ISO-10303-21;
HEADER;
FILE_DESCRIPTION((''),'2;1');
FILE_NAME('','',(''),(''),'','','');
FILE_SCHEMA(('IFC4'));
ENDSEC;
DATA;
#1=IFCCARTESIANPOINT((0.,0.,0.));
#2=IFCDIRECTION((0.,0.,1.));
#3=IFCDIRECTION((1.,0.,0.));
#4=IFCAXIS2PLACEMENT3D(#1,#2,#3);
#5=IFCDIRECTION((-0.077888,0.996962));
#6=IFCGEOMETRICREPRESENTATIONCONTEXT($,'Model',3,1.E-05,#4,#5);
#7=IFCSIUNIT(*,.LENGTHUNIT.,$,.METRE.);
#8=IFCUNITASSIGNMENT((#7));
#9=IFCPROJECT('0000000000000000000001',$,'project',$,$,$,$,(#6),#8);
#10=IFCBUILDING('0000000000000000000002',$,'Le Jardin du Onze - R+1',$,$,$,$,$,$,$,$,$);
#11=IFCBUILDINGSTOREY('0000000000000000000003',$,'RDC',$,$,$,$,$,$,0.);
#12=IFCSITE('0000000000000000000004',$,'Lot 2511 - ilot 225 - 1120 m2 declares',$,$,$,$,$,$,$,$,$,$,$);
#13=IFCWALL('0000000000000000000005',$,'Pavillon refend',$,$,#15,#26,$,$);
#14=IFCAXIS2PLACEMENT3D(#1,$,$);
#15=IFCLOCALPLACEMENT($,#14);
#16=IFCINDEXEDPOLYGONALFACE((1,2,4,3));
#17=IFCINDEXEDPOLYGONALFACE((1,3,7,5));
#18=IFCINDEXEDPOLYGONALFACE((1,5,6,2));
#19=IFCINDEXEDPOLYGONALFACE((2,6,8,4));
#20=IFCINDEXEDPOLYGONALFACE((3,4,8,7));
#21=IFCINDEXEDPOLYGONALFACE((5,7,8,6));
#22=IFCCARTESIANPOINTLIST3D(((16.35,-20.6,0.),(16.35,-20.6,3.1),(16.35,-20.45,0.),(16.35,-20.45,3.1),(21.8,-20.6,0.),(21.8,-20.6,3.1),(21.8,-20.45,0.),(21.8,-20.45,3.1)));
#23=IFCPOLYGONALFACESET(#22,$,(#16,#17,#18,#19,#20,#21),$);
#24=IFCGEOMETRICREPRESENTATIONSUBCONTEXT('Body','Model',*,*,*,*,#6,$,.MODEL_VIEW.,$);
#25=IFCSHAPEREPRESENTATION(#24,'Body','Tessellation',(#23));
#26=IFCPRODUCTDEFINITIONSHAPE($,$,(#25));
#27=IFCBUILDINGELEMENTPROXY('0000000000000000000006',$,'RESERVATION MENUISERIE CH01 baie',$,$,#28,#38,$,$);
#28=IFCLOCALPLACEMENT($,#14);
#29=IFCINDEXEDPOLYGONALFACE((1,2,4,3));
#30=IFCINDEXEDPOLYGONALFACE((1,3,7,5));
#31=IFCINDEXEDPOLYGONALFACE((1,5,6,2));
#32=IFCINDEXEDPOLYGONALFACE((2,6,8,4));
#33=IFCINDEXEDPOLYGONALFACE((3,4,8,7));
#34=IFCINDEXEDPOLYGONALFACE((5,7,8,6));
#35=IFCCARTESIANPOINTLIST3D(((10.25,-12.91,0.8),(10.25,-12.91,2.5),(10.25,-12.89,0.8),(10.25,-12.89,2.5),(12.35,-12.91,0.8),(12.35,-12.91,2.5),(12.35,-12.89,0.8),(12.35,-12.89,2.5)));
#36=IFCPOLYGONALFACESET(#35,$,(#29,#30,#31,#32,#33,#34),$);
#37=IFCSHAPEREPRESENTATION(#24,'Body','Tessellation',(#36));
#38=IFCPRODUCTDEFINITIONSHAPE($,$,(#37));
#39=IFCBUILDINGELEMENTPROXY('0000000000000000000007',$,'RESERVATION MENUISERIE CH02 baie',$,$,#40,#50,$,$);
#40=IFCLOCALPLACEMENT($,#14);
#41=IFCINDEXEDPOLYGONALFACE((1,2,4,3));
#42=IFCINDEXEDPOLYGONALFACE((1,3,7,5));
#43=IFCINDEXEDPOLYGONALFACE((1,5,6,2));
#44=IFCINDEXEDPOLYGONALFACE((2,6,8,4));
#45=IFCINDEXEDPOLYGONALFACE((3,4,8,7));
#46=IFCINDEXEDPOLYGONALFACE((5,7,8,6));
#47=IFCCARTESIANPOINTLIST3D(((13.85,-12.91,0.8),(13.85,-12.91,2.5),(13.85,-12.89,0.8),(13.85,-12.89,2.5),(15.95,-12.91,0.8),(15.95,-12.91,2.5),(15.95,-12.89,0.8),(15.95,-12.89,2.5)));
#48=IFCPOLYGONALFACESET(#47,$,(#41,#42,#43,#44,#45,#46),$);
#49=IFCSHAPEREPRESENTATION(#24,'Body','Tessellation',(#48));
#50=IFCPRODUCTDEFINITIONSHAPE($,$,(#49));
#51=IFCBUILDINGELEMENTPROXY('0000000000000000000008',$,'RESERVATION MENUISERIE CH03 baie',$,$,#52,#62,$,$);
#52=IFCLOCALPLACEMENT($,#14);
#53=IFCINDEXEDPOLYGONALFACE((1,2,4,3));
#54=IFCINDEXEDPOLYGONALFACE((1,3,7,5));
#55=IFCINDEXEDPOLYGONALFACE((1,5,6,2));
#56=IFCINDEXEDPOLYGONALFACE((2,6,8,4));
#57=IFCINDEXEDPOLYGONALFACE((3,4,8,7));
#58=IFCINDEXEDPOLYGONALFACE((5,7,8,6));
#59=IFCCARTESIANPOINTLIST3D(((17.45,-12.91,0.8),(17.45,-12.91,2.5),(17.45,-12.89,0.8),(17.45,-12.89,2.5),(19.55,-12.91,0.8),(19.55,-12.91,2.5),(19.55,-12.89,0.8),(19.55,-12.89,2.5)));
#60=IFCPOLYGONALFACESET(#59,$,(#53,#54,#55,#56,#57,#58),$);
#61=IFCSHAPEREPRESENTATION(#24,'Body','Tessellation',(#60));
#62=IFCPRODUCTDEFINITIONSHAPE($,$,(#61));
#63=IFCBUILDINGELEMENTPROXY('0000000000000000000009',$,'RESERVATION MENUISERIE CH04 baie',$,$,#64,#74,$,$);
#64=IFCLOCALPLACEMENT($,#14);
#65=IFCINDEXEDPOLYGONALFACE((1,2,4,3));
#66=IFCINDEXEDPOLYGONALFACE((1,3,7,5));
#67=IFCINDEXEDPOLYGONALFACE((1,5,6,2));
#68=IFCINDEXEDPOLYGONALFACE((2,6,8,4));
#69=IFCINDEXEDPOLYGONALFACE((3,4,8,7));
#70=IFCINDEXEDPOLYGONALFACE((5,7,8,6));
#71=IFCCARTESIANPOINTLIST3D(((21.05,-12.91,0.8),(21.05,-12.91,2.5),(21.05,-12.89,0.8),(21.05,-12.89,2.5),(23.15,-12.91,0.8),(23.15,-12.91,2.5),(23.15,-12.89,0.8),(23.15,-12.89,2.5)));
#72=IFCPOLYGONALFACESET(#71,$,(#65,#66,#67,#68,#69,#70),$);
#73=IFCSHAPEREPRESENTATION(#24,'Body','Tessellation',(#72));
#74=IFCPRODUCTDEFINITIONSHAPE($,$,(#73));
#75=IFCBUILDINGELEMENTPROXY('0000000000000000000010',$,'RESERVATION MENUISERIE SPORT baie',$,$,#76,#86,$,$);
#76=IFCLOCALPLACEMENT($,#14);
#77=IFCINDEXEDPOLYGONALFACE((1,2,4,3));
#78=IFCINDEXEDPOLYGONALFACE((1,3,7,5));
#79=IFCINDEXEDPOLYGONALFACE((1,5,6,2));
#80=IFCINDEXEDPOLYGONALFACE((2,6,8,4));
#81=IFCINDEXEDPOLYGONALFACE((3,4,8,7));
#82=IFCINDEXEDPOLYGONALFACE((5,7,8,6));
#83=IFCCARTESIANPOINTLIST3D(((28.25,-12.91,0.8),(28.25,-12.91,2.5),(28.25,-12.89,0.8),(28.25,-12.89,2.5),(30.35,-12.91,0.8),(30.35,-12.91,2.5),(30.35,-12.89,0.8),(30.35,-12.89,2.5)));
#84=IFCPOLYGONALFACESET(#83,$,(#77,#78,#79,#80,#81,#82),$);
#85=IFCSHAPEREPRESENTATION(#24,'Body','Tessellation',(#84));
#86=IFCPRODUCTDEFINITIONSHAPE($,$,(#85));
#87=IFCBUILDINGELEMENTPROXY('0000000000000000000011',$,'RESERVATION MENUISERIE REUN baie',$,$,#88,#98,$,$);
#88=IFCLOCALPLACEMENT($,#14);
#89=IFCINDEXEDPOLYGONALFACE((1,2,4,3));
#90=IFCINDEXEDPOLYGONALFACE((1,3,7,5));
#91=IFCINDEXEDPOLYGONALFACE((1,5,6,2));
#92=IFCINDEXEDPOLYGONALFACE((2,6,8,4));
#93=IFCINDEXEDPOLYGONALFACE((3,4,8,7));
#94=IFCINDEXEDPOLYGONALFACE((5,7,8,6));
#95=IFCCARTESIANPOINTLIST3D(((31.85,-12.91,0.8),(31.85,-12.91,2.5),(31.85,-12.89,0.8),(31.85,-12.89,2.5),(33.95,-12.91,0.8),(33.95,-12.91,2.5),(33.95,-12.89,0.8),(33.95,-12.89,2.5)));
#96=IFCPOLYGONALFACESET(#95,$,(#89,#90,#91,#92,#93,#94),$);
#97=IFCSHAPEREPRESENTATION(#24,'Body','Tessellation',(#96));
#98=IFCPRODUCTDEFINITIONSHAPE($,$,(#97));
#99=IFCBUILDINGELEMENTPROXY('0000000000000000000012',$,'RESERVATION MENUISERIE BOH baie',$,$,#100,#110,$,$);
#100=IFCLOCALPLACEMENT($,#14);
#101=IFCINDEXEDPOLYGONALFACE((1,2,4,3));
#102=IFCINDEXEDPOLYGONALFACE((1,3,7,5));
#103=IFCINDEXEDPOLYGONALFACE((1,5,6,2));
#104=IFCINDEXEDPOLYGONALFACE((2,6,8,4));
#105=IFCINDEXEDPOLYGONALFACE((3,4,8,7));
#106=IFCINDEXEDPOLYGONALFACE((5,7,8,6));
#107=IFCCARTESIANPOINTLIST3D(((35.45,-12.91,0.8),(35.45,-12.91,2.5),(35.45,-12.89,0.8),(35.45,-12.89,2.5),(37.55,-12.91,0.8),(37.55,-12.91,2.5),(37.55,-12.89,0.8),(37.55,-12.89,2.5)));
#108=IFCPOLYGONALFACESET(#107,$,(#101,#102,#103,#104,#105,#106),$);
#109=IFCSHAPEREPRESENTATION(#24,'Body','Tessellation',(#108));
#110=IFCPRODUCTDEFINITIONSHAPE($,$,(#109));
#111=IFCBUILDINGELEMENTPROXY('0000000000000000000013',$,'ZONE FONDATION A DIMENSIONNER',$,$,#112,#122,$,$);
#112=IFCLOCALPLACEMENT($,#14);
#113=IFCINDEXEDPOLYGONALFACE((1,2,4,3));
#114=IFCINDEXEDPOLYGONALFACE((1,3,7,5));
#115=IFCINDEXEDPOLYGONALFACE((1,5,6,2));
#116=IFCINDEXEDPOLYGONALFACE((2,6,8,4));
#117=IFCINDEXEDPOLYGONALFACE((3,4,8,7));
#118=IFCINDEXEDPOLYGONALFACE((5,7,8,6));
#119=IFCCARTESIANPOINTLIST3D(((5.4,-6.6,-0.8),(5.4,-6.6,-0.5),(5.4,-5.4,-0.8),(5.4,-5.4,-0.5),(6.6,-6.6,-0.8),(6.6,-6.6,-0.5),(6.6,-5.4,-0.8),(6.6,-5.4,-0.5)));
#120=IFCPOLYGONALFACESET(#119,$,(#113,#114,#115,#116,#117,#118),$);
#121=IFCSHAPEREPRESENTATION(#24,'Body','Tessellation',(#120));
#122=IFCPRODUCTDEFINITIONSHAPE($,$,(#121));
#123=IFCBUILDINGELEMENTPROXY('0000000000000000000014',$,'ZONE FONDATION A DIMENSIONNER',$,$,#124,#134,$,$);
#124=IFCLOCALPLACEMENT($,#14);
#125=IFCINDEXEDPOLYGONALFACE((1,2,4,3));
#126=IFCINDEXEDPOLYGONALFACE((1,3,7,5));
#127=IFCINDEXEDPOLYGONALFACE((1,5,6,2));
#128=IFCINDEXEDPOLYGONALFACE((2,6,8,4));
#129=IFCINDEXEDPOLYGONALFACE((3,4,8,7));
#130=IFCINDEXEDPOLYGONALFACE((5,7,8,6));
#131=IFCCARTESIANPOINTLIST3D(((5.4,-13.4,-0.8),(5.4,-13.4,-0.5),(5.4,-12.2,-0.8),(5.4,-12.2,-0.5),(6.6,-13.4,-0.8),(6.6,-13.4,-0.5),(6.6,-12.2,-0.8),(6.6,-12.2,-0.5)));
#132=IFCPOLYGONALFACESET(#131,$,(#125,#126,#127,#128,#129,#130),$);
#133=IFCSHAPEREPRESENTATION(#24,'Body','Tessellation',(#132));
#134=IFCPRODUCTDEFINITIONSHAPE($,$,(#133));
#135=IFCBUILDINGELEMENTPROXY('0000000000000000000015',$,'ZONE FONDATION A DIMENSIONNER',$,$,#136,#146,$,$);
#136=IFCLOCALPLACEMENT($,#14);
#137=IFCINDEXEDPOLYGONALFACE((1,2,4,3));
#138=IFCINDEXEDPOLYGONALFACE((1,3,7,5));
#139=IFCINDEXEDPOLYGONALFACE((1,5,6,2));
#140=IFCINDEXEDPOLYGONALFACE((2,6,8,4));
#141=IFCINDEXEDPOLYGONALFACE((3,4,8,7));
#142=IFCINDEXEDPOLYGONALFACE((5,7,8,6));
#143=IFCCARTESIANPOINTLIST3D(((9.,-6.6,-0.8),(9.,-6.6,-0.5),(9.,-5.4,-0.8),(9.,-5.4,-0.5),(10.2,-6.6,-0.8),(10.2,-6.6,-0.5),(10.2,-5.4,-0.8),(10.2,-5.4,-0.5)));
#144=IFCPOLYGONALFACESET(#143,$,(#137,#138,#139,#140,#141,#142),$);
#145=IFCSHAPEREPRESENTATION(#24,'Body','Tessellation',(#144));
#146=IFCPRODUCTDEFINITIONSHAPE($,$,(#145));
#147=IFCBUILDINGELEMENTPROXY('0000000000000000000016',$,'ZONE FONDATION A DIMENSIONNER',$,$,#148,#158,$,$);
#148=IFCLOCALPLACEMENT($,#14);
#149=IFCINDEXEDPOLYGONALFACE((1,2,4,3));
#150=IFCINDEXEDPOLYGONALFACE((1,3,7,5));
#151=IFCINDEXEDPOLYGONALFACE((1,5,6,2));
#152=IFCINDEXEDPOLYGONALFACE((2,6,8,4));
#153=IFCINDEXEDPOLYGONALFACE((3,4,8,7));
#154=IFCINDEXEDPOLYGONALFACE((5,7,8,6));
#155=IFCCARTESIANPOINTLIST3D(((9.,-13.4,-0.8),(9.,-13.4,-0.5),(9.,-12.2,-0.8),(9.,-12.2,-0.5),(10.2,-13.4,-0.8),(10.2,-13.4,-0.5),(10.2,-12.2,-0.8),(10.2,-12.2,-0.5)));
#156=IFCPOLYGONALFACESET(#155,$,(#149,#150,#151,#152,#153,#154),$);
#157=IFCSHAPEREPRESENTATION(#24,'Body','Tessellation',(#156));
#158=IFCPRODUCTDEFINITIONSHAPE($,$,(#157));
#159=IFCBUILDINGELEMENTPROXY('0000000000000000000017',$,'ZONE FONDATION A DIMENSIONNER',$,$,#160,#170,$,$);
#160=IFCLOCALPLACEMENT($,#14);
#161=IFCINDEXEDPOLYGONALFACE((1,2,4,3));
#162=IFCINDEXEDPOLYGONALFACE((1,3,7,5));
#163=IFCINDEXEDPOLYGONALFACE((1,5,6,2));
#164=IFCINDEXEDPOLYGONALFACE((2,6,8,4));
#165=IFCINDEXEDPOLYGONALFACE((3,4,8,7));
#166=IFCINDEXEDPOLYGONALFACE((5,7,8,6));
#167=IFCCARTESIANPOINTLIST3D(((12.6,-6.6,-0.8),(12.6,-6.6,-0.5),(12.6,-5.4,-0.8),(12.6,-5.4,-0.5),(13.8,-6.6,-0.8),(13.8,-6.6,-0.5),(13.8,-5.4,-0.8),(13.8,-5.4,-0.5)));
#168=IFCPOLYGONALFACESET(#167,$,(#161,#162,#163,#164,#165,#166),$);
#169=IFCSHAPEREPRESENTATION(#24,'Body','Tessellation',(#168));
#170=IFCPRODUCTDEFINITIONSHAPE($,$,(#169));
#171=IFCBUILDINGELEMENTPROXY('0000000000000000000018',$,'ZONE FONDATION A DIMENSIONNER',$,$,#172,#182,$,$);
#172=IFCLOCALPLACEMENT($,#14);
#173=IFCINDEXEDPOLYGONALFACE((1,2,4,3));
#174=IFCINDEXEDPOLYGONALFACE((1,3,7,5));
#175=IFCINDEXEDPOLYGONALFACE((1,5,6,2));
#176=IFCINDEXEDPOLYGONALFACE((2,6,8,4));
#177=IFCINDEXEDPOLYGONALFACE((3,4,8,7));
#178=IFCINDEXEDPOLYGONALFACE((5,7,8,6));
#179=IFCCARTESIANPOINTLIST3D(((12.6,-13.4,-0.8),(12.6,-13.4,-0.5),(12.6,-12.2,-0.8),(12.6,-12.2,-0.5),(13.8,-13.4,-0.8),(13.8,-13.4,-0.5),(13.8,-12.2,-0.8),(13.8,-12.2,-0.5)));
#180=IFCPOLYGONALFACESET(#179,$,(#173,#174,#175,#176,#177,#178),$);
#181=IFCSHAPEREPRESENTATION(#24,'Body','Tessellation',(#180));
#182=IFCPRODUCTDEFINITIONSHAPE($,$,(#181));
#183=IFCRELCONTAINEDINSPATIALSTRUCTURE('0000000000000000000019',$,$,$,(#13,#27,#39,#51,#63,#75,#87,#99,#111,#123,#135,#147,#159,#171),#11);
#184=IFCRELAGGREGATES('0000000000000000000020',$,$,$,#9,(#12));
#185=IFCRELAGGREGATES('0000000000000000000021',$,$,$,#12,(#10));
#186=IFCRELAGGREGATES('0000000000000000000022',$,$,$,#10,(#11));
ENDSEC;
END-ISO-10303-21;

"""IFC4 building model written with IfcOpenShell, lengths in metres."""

from ifc_helpers import new_model, si_unit, direction, frame, origin, origin_with_axes, place, context, subcontext, project, spatial, polyline, outline, extrude, element, save


model = new_model("IFC4")

# Units and contexts
model_context = context("Model", 3, precision=1e-05, world=origin_with_axes(), true_north=direction((-0.077888, 0.996962)))
body_context = subcontext(model_context, "Body", "Model", "MODEL_VIEW")
ifc_project = project(units=[si_unit("LENGTHUNIT", "METRE")], contexts=[model_context])

# Site, building, storey
site = spatial("IfcSite", under=ifc_project, Name="Lot 2511 - ilot 225 - 1120 m2 declares")
building = spatial("IfcBuilding", under=site, Name="Le Jardin du Onze - R+1")
storey = spatial("IfcBuildingStorey", under=building, Name="RDC", Elevation=0.0)

# Wall
wall_1_placement = place(None, origin_with_axes())
element("IfcWall", 1, at=wall_1_placement, inside=storey, Name="Pavillon refend", context=body_context, shape_type="SweptSolid", body=[
    extrude(outline(polyline([(21.8, -20.6), (21.8, -20.45), (16.35, -20.45), (16.35, -20.6), (21.8, -20.6)])), origin(), (0.0, 0.0, 1.0), 3.1),
])

# Building element proxies
proxy_1_placement = place(None, origin_with_axes())
element("IfcBuildingElementProxy", 2, at=proxy_1_placement, inside=storey, Name="RESERVATION MENUISERIE CH01 baie", context=body_context, shape_type="SweptSolid", body=[
    extrude(outline(polyline([(12.35, -12.91), (12.35, -12.89), (10.25, -12.89), (10.25, -12.91), (12.35, -12.91)])), frame((0.0, 0.0, 0.8)), (0.0, 0.0, 1.0), 1.7),
])
proxy_2_placement = place(None, origin_with_axes())
element("IfcBuildingElementProxy", 3, at=proxy_2_placement, inside=storey, Name="RESERVATION MENUISERIE CH02 baie", context=body_context, shape_type="SweptSolid", body=[
    extrude(outline(polyline([(15.95, -12.91), (15.95, -12.89), (13.85, -12.89), (13.85, -12.91), (15.95, -12.91)])), frame((0.0, 0.0, 0.8)), (0.0, 0.0, 1.0), 1.7),
])
proxy_3_placement = place(None, origin_with_axes())
element("IfcBuildingElementProxy", 4, at=proxy_3_placement, inside=storey, Name="RESERVATION MENUISERIE CH03 baie", context=body_context, shape_type="SweptSolid", body=[
    extrude(outline(polyline([(19.55, -12.91), (19.55, -12.89), (17.45, -12.89), (17.45, -12.91), (19.55, -12.91)])), frame((0.0, 0.0, 0.8)), (0.0, 0.0, 1.0), 1.7),
])
proxy_4_placement = place(None, origin_with_axes())
element("IfcBuildingElementProxy", 5, at=proxy_4_placement, inside=storey, Name="RESERVATION MENUISERIE CH04 baie", context=body_context, shape_type="SweptSolid", body=[
    extrude(outline(polyline([(23.15, -12.91), (23.15, -12.89), (21.05, -12.89), (21.05, -12.91), (23.15, -12.91)])), frame((0.0, 0.0, 0.8)), (0.0, 0.0, 1.0), 1.7),
])
proxy_5_placement = place(None, origin_with_axes())
element("IfcBuildingElementProxy", 6, at=proxy_5_placement, inside=storey, Name="RESERVATION MENUISERIE SPORT baie", context=body_context, shape_type="SweptSolid", body=[
    extrude(outline(polyline([(30.35, -12.91), (30.35, -12.89), (28.25, -12.89), (28.25, -12.91), (30.35, -12.91)])), frame((0.0, 0.0, 0.8)), (0.0, 0.0, 1.0), 1.7),
])
proxy_6_placement = place(None, origin_with_axes())
element("IfcBuildingElementProxy", 7, at=proxy_6_placement, inside=storey, Name="RESERVATION MENUISERIE REUN baie", context=body_context, shape_type="SweptSolid", body=[
    extrude(outline(polyline([(33.95, -12.91), (33.95, -12.89), (31.85, -12.89), (31.85, -12.91), (33.95, -12.91)])), frame((0.0, 0.0, 0.8)), (0.0, 0.0, 1.0), 1.7),
])
proxy_7_placement = place(None, origin_with_axes())
element("IfcBuildingElementProxy", 8, at=proxy_7_placement, inside=storey, Name="RESERVATION MENUISERIE BOH baie", context=body_context, shape_type="SweptSolid", body=[
    extrude(outline(polyline([(37.55, -12.91), (37.55, -12.89), (35.45, -12.89), (35.45, -12.91), (37.55, -12.91)])), frame((0.0, 0.0, 0.8)), (0.0, 0.0, 1.0), 1.7),
])
proxy_8_placement = place(None, origin_with_axes())
element("IfcBuildingElementProxy", 9, at=proxy_8_placement, inside=storey, Name="ZONE FONDATION A DIMENSIONNER", context=body_context, shape_type="SweptSolid", body=[
    extrude(outline(polyline([(6.6, -6.6), (6.6, -5.4), (5.4, -5.4), (5.4, -6.6), (6.6, -6.6)])), frame((0.0, 0.0, -0.8)), (0.0, 0.0, 1.0), 0.3),
])
proxy_9_placement = place(None, origin_with_axes())
element("IfcBuildingElementProxy", 10, at=proxy_9_placement, inside=storey, Name="ZONE FONDATION A DIMENSIONNER", context=body_context, shape_type="SweptSolid", body=[
    extrude(outline(polyline([(6.6, -13.4), (6.6, -12.2), (5.4, -12.2), (5.4, -13.4), (6.6, -13.4)])), frame((0.0, 0.0, -0.8)), (0.0, 0.0, 1.0), 0.3),
])
proxy_10_placement = place(None, origin_with_axes())
element("IfcBuildingElementProxy", 11, at=proxy_10_placement, inside=storey, Name="ZONE FONDATION A DIMENSIONNER", context=body_context, shape_type="SweptSolid", body=[
    extrude(outline(polyline([(10.2, -6.6), (10.2, -5.4), (9.0, -5.4), (9.0, -6.6), (10.2, -6.6)])), frame((0.0, 0.0, -0.8)), (0.0, 0.0, 1.0), 0.3),
])
proxy_11_placement = place(None, origin_with_axes())
element("IfcBuildingElementProxy", 12, at=proxy_11_placement, inside=storey, Name="ZONE FONDATION A DIMENSIONNER", context=body_context, shape_type="SweptSolid", body=[
    extrude(outline(polyline([(10.2, -13.4), (10.2, -12.2), (9.0, -12.2), (9.0, -13.4), (10.2, -13.4)])), frame((0.0, 0.0, -0.8)), (0.0, 0.0, 1.0), 0.3),
])
proxy_12_placement = place(None, origin_with_axes())
element("IfcBuildingElementProxy", 13, at=proxy_12_placement, inside=storey, Name="ZONE FONDATION A DIMENSIONNER", context=body_context, shape_type="SweptSolid", body=[
    extrude(outline(polyline([(13.8, -6.6), (13.8, -5.4), (12.6, -5.4), (12.6, -6.6), (13.8, -6.6)])), frame((0.0, 0.0, -0.8)), (0.0, 0.0, 1.0), 0.3),
])
proxy_13_placement = place(None, origin_with_axes())
element("IfcBuildingElementProxy", 14, at=proxy_13_placement, inside=storey, Name="ZONE FONDATION A DIMENSIONNER", context=body_context, shape_type="SweptSolid", body=[
    extrude(outline(polyline([(13.8, -13.4), (13.8, -12.2), (12.6, -12.2), (12.6, -13.4), (13.8, -13.4)])), frame((0.0, 0.0, -0.8)), (0.0, 0.0, 1.0), 0.3),
])

save(model, "model.ifc")
